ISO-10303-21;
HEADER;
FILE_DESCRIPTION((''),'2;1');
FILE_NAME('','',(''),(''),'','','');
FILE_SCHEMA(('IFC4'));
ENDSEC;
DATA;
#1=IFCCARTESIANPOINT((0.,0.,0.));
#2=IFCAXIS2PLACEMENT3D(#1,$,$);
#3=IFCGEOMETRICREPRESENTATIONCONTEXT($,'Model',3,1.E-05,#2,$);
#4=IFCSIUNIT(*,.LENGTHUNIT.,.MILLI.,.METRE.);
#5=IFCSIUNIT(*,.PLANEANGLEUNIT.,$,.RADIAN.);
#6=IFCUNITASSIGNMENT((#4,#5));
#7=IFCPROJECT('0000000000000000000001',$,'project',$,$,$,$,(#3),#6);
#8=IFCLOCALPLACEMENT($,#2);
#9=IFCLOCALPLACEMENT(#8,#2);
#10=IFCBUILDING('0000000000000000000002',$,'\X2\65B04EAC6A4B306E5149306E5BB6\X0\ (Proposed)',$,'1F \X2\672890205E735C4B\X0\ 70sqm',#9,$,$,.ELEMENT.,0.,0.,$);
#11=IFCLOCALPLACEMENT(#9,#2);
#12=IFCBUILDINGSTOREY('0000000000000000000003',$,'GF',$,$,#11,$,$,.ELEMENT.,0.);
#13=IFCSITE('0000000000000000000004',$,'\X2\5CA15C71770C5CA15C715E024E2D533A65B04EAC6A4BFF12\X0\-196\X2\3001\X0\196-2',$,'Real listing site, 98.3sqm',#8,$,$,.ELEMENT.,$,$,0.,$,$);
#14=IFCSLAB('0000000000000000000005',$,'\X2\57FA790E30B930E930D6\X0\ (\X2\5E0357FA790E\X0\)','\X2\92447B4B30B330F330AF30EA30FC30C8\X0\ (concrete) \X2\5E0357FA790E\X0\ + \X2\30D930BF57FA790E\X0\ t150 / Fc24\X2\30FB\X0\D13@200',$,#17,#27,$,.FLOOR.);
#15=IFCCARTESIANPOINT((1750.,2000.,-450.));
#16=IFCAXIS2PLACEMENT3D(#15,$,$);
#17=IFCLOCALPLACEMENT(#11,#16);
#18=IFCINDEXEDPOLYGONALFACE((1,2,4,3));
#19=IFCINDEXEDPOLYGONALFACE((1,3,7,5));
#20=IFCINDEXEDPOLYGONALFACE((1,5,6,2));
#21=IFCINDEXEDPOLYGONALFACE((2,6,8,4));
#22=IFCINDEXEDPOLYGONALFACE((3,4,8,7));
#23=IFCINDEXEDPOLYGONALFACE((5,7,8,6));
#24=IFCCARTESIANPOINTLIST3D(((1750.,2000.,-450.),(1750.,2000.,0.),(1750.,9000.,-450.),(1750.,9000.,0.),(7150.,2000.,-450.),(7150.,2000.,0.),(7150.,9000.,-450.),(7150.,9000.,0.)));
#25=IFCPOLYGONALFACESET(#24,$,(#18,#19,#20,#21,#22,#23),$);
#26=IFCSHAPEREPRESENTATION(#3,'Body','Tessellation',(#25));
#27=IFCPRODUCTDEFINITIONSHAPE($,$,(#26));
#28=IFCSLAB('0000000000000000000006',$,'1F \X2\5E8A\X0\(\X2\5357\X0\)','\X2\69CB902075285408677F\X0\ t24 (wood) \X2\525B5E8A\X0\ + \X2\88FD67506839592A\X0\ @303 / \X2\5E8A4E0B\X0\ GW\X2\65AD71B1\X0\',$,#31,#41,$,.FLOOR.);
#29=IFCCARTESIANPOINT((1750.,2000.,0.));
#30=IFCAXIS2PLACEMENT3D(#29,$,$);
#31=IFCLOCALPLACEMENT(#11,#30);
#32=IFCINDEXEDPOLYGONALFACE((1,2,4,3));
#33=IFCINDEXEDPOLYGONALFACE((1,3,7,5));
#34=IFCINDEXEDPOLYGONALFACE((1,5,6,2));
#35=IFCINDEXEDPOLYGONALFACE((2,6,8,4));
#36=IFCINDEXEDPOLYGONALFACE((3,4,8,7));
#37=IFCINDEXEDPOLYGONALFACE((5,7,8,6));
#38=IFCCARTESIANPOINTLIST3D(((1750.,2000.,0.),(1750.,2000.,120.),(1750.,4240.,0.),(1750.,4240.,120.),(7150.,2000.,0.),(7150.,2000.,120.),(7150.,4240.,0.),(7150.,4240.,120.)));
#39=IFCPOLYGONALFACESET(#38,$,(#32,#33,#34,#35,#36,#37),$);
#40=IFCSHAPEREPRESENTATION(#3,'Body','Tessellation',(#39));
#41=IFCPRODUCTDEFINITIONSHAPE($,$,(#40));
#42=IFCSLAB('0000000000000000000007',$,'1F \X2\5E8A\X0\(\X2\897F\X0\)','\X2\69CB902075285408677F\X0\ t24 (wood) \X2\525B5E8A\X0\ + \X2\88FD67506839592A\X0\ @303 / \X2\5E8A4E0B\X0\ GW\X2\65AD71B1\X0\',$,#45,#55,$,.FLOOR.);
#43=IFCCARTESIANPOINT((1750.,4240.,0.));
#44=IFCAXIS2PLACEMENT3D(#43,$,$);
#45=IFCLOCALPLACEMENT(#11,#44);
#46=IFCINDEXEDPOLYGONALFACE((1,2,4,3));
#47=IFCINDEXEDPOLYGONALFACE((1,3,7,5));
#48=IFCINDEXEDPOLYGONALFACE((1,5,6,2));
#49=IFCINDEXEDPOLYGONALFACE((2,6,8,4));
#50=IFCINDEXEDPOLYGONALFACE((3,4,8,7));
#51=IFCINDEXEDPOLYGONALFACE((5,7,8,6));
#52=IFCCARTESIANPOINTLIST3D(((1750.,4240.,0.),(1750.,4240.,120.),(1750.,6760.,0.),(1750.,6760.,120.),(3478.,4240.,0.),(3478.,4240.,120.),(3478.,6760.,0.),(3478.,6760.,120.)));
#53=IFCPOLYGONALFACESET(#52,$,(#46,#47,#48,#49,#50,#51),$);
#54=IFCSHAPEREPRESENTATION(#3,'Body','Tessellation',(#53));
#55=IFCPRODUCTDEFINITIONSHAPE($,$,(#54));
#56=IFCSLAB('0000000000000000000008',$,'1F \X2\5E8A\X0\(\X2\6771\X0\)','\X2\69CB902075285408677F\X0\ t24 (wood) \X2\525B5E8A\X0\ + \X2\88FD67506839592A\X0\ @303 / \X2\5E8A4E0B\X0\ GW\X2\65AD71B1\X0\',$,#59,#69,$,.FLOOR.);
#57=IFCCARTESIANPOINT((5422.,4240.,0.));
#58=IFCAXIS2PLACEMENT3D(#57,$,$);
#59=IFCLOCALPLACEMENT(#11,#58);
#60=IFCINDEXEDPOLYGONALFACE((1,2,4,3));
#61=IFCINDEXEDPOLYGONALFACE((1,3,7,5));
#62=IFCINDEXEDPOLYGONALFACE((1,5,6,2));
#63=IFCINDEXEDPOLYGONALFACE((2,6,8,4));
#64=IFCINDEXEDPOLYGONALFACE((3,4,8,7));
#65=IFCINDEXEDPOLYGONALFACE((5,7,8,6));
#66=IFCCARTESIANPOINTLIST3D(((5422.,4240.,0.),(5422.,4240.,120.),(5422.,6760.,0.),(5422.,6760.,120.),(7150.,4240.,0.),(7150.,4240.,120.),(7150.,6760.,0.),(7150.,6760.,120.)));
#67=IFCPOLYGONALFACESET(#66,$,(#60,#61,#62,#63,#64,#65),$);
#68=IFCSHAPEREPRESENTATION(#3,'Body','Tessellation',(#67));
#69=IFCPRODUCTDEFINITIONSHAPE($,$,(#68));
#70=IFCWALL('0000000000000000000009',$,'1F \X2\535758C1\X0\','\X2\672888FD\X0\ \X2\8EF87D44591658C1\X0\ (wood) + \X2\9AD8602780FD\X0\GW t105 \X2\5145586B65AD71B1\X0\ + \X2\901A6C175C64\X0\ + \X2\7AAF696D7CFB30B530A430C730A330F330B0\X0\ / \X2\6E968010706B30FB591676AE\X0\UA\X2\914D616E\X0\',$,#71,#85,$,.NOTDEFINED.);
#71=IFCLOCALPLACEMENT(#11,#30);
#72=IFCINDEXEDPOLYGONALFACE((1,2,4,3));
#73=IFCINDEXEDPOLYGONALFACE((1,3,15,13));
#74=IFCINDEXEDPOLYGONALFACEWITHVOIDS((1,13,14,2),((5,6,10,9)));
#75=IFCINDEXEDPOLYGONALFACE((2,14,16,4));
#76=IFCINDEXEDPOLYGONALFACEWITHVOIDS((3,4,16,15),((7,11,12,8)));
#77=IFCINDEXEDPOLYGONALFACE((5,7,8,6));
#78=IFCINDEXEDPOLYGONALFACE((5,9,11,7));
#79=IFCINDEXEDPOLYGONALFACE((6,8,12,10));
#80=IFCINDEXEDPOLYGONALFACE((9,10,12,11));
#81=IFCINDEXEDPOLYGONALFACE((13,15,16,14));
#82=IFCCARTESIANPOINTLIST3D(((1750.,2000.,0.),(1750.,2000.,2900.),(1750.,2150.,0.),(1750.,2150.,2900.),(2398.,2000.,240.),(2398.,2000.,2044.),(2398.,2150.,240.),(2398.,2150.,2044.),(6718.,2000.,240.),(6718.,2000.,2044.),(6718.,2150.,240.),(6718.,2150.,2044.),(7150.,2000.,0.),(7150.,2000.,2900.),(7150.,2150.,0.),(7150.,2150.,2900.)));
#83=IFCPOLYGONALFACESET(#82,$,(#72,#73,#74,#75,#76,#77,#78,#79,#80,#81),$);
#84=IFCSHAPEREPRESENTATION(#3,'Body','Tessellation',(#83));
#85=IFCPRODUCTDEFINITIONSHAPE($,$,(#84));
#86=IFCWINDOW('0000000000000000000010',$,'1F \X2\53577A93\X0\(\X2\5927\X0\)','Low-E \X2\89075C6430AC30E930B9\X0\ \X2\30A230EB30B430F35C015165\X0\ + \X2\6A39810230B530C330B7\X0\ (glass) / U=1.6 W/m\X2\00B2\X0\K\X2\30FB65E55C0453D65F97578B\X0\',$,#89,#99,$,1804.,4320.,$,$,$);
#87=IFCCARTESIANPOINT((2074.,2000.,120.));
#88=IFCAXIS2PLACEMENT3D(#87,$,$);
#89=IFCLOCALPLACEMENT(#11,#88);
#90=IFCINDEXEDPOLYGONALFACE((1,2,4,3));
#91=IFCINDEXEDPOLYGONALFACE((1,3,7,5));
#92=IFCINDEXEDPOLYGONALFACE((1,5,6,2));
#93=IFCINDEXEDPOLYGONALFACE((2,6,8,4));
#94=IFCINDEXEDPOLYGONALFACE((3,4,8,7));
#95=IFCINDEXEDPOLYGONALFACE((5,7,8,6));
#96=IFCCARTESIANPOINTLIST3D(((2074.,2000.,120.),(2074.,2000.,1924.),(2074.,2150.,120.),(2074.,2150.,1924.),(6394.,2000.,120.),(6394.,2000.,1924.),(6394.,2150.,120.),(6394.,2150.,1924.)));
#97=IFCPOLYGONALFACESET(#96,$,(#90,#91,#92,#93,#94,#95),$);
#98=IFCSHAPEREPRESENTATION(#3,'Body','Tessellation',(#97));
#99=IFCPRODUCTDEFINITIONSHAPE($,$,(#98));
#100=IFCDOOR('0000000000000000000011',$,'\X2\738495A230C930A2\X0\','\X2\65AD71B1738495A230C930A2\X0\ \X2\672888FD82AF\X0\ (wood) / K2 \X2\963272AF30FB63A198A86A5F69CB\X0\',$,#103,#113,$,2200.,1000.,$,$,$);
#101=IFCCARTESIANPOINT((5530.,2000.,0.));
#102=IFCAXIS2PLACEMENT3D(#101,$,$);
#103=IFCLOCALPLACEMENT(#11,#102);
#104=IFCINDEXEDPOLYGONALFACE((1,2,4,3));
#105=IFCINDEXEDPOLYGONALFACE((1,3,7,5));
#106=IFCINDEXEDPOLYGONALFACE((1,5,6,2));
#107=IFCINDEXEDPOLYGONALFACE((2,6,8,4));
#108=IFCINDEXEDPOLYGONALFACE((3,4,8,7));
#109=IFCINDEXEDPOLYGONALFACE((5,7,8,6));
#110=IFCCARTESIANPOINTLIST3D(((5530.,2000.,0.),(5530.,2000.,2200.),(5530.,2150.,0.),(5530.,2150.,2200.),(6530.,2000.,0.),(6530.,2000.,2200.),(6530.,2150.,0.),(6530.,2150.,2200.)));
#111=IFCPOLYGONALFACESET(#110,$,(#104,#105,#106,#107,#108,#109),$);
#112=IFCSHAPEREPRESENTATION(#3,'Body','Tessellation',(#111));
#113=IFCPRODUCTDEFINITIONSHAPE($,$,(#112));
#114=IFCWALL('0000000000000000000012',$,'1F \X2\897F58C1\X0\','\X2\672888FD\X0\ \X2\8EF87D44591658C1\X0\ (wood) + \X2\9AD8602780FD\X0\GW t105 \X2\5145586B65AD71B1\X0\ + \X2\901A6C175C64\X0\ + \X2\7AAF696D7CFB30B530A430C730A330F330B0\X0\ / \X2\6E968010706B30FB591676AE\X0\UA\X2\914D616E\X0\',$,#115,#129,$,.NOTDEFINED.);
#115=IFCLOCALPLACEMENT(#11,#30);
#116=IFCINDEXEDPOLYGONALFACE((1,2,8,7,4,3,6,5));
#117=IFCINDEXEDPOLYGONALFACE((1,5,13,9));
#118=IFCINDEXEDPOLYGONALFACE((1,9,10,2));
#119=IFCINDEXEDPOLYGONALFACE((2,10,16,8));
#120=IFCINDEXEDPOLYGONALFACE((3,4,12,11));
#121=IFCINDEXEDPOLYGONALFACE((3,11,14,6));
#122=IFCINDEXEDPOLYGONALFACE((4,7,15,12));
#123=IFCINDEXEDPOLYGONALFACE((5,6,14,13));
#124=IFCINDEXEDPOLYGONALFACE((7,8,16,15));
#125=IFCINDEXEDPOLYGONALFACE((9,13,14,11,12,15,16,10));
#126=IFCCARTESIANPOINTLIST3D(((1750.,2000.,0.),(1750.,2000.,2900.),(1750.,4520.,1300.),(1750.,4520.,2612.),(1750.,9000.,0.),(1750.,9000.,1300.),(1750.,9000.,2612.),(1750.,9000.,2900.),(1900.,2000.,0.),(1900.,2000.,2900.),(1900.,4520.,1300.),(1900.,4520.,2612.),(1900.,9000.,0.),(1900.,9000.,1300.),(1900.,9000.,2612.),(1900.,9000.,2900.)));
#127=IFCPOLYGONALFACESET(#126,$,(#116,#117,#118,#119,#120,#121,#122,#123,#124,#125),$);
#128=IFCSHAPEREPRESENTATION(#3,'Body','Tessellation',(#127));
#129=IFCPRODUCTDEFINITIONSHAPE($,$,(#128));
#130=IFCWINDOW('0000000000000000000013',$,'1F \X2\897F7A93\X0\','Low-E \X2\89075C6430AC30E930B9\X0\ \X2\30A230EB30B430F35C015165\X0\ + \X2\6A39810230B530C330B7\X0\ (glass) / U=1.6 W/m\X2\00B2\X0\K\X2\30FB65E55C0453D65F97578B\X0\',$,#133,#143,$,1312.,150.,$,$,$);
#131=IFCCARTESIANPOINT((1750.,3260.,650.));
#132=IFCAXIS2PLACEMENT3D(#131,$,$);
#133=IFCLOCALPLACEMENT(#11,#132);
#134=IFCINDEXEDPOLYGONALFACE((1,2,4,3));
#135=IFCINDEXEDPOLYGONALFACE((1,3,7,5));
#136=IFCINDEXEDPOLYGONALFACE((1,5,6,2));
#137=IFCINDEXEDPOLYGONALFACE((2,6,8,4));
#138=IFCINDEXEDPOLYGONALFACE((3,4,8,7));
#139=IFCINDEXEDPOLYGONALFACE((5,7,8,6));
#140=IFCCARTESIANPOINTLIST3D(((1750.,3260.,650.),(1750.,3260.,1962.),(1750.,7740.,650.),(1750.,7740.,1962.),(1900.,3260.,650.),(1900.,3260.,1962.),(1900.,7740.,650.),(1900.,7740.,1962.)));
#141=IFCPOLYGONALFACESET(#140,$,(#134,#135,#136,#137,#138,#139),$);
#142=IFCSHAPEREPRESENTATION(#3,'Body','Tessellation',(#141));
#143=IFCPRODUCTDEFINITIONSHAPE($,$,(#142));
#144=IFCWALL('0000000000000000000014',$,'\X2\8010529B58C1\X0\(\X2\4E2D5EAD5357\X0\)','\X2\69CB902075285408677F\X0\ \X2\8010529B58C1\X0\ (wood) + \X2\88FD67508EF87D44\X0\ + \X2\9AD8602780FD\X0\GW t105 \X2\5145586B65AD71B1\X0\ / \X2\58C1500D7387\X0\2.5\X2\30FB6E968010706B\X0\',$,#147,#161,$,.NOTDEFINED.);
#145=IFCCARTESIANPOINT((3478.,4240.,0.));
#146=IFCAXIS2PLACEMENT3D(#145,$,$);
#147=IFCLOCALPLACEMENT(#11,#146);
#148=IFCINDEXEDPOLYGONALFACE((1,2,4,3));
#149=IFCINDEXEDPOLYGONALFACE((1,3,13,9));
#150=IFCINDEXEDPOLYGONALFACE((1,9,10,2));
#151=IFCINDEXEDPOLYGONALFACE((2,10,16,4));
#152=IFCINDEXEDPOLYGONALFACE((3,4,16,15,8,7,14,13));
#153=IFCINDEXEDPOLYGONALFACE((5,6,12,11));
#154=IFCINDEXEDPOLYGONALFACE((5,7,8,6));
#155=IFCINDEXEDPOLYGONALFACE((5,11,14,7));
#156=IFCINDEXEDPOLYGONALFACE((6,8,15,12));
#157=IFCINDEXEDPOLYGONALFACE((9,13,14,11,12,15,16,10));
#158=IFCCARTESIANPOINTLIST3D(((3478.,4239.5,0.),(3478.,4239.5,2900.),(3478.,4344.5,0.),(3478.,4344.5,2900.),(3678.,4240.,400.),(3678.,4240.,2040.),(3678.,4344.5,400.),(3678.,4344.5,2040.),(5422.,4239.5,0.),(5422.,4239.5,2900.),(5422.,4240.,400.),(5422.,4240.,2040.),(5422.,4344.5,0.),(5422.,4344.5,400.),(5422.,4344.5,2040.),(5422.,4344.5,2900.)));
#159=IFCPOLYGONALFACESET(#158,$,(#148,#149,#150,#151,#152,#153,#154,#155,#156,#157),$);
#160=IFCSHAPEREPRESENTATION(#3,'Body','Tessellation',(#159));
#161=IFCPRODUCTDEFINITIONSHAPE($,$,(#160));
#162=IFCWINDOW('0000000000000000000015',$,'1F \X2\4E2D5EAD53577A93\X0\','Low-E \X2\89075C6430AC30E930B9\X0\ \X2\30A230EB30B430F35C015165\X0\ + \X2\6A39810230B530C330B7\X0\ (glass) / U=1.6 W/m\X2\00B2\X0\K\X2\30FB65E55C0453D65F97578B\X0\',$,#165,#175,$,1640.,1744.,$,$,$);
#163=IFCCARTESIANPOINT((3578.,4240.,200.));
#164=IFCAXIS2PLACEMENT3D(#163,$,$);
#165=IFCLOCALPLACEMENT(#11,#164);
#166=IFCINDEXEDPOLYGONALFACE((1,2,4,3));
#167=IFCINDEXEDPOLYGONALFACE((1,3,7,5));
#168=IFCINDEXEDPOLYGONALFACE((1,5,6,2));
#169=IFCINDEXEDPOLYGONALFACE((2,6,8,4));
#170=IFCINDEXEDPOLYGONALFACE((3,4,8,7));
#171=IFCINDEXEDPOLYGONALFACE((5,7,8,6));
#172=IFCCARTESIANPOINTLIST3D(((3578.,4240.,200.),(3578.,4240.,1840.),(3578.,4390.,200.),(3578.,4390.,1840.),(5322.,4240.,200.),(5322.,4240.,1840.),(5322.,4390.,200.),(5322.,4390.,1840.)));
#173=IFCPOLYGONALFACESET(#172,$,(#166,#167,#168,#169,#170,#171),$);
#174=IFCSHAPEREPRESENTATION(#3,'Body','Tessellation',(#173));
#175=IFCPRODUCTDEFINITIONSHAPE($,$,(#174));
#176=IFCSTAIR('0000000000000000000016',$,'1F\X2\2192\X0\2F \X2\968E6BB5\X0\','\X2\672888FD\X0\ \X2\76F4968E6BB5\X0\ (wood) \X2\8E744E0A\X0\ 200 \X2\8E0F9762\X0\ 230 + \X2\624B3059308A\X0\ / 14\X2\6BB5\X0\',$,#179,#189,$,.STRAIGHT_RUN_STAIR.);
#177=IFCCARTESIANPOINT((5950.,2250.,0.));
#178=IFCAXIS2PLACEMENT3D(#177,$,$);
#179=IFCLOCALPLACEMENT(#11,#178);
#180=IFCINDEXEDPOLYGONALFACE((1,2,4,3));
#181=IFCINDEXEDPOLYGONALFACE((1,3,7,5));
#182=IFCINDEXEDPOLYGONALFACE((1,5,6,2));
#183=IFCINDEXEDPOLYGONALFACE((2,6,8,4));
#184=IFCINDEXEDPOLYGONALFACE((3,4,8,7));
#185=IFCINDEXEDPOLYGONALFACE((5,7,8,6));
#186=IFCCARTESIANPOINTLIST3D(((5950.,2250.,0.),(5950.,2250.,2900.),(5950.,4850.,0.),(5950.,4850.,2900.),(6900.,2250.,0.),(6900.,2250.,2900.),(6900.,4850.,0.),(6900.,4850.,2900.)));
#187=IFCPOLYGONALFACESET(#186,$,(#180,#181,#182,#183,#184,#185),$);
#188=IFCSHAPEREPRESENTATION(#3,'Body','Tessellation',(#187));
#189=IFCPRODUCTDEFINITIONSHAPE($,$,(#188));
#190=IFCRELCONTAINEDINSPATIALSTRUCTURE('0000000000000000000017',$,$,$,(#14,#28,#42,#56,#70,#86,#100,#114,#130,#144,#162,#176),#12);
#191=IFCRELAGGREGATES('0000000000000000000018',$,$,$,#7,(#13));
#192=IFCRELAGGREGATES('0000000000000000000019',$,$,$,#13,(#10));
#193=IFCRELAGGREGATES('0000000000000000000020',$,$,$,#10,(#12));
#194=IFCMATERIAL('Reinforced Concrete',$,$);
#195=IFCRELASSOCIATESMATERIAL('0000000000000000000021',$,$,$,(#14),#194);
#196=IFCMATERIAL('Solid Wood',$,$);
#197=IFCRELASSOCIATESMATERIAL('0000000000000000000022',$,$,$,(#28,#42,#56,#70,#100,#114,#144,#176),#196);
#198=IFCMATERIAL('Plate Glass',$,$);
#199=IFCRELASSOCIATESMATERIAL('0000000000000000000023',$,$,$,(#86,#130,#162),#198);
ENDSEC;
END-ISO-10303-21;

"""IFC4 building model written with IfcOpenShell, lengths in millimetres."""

from ifc_helpers import new_model, si_unit, frame, frame_2d, origin, place, context, project, spatial, rectangle, extrude, material, element, fill, save


model = new_model("IFC4")

# Units and contexts
model_context = context("Model", 3, precision=1e-05, world=origin())
ifc_project = project(units=[si_unit("LENGTHUNIT", "METRE", prefix="MILLI"), si_unit("PLANEANGLEUNIT", "RADIAN")], contexts=[model_context])

# Site, building, storey
site_placement = place(None, origin())
site = spatial("IfcSite", under=ifc_project, at=site_placement, Name="岡山県岡山市中区新京橋２-196、196-2", ObjectType="Real listing site, 98.3sqm", CompositionType="ELEMENT", RefElevation=0.0)
building_placement = place(site_placement, origin())
building = spatial("IfcBuilding", under=site, at=building_placement, Name="新京橋の光の家 (Proposed)", ObjectType="1F 木造平屋 70sqm", CompositionType="ELEMENT", ElevationOfRefHeight=0.0, ElevationOfTerrain=0.0)
storey_placement = place(building_placement, origin())
storey = spatial("IfcBuildingStorey", under=building, at=storey_placement, Name="GF", CompositionType="ELEMENT", Elevation=0.0)

# Slabs
ifc_material_1 = material(Name="Reinforced Concrete")
slab_1_placement = place(storey_placement, frame((1750.0, 2000.0, -450.0)))
element("IfcSlab", 1, at=slab_1_placement, inside=storey, material=ifc_material_1, Name="基礎スラブ (布基礎)", Description="鉄筋コンクリート (concrete) 布基礎 + ベタ基礎 t150 / Fc24・D13@200", PredefinedType="FLOOR", context=model_context, shape_type="SweptSolid", body=[
    extrude(rectangle(XDim=5400.0, YDim=7000.0, at=frame_2d((2700.0, 3500.0))), frame((1750.0, 2000.0, -450.0)), (0.0, 0.0, 1.0), 450.0),
])
ifc_material_2 = material(Name="Solid Wood")
slab_2_placement = place(storey_placement, frame((1750.0, 2000.0, 0.0)))
element("IfcSlab", 2, at=slab_2_placement, inside=storey, material=ifc_material_2, Name="1F 床(南)", Description="構造用合板 t24 (wood) 剛床 + 製材根太 @303 / 床下 GW断熱", PredefinedType="FLOOR", context=model_context, shape_type="SweptSolid", body=[
    extrude(rectangle(XDim=5400.0, YDim=2240.0, at=frame_2d((2700.0, 1120.0))), frame((1750.0, 2000.0, 0.0)), (0.0, 0.0, 1.0), 120.0),
])
slab_3_placement = place(storey_placement, frame((1750.0, 4240.0, 0.0)))
element("IfcSlab", 3, at=slab_3_placement, inside=storey, material=ifc_material_2, Name="1F 床(西)", Description="構造用合板 t24 (wood) 剛床 + 製材根太 @303 / 床下 GW断熱", PredefinedType="FLOOR", context=model_context, shape_type="SweptSolid", body=[
    extrude(rectangle(XDim=1728.0, YDim=2520.0, at=frame_2d((864.0, 1260.0))), frame((1750.0, 4240.0, 0.0)), (0.0, 0.0, 1.0), 120.0),
])
slab_4_placement = place(storey_placement, frame((5422.0, 4240.0, 0.0)))
element("IfcSlab", 4, at=slab_4_placement, inside=storey, material=ifc_material_2, Name="1F 床(東)", Description="構造用合板 t24 (wood) 剛床 + 製材根太 @303 / 床下 GW断熱", PredefinedType="FLOOR", context=model_context, shape_type="SweptSolid", body=[
    extrude(rectangle(XDim=1728.0, YDim=2520.0, at=frame_2d((864.0, 1260.0))), frame((5422.0, 4240.0, 0.0)), (0.0, 0.0, 1.0), 120.0),
])

# Wall, openings, window, door
wall_1_placement = place(storey_placement, frame((1750.0, 2000.0, 0.0)))
wall_1 = element("IfcWall", 5, at=wall_1_placement, inside=storey, material=ifc_material_2, Name="1F 南壁", Description="木製 軸組外壁 (wood) + 高性能GW t105 充填断熱 + 通気層 + 窯業系サイディング / 準耐火・外皮UA配慮", PredefinedType="NOTDEFINED", context=model_context, shape_type="SweptSolid", body=[
    extrude(rectangle(XDim=5400.0, YDim=150.0, at=frame_2d((2700.0, 75.0))), frame((1750.0, 2000.0, 0.0)), (0.0, 0.0, 1.0), 2900.0),
])
opening_1_placement = place(storey_placement, frame((2074.0, 2000.0, 120.0)))
opening_1 = element("IfcOpeningElement", 6, at=opening_1_placement, cuts=wall_1, PredefinedType="NOTDEFINED", context=model_context, shape_type="SweptSolid", body=[
    extrude(rectangle(XDim=4320.0, YDim=150.0, at=frame_2d((2160.0, 75.0))), frame((2074.0, 2000.0, 120.0)), (0.0, 0.0, 1.0), 1804.0),
])
opening_2_placement = place(storey_placement, frame((5530.0, 2000.0, 0.0)))
opening_2 = element("IfcOpeningElement", 7, at=opening_2_placement, cuts=wall_1, PredefinedType="NOTDEFINED", context=model_context, shape_type="SweptSolid", body=[
    extrude(rectangle(XDim=1000.0, YDim=150.0, at=frame_2d((500.0, 75.0))), frame((5530.0, 2000.0, 0.0)), (0.0, 0.0, 1.0), 2200.0),
])
ifc_material_3 = material(Name="Plate Glass")
window_1_placement = place(storey_placement, frame((2074.0, 2000.0, 120.0)))
window_1 = element("IfcWindow", 8, at=window_1_placement, inside=storey, material=ifc_material_3, Name="1F 南窓(大)", Description="Low-E 複層ガラス アルゴン封入 + 樹脂サッシ (glass) / U=1.6 W/m²K・日射取得型", OverallHeight=1804.0, OverallWidth=4320.0, context=model_context, shape_type="SweptSolid", body=[
    extrude(rectangle(XDim=4320.0, YDim=150.0, at=frame_2d((2160.0, 75.0))), frame((2074.0, 2000.0, 120.0)), (0.0, 0.0, 1.0), 1804.0),
])
fill(opening_1, window_1)
door_placement = place(storey_placement, frame((5530.0, 2000.0, 0.0)))
door = element("IfcDoor", 9, at=door_placement, inside=storey, material=ifc_material_2, Name="玄関ドア", Description="断熱玄関ドア 木製芯 (wood) / K2 防犯・採風機構", OverallHeight=2200.0, OverallWidth=1000.0, context=model_context, shape_type="SweptSolid", body=[
    extrude(rectangle(XDim=1000.0, YDim=150.0, at=frame_2d((500.0, 75.0))), frame((5530.0, 2000.0, 0.0)), (0.0, 0.0, 1.0), 2200.0),
])
fill(opening_2, door)

# Walls, openings, windows
wall_2_placement = place(storey_placement, frame((1750.0, 2000.0, 0.0)))
wall_2 = element("IfcWall", 10, at=wall_2_placement, inside=storey, material=ifc_material_2, Name="1F 西壁", Description="木製 軸組外壁 (wood) + 高性能GW t105 充填断熱 + 通気層 + 窯業系サイディング / 準耐火・外皮UA配慮", PredefinedType="NOTDEFINED", context=model_context, shape_type="SweptSolid", body=[
    extrude(rectangle(XDim=150.0, YDim=7000.0, at=frame_2d((75.0, 3500.0))), frame((1750.0, 2000.0, 0.0)), (0.0, 0.0, 1.0), 2900.0),
])
opening_3_placement = place(storey_placement, frame((1750.0, 3260.0, 650.0)))
opening_3 = element("IfcOpeningElement", 11, at=opening_3_placement, cuts=wall_2, PredefinedType="NOTDEFINED", context=model_context, shape_type="SweptSolid", body=[
    extrude(rectangle(XDim=150.0, YDim=4480.0, at=frame_2d((75.0, 2240.0))), frame((1750.0, 3260.0, 650.0)), (0.0, 0.0, 1.0), 1312.0),
])
window_2_placement = place(storey_placement, frame((1750.0, 3260.0, 650.0)))
window_2 = element("IfcWindow", 12, at=window_2_placement, inside=storey, material=ifc_material_3, Name="1F 西窓", Description="Low-E 複層ガラス アルゴン封入 + 樹脂サッシ (glass) / U=1.6 W/m²K・日射取得型", OverallHeight=1312.0, OverallWidth=150.0, context=model_context, shape_type="SweptSolid", body=[
    extrude(rectangle(XDim=150.0, YDim=4480.0, at=frame_2d((75.0, 2240.0))), frame((1750.0, 3260.0, 650.0)), (0.0, 0.0, 1.0), 1312.0),
])
fill(opening_3, window_2)
wall_3_placement = place(storey_placement, frame((3478.0, 4240.0, 0.0)))
wall_3 = element("IfcWall", 13, at=wall_3_placement, inside=storey, material=ifc_material_2, Name="耐力壁(中庭南)", Description="構造用合板 耐力壁 (wood) + 製材軸組 + 高性能GW t105 充填断熱 / 壁倍率2.5・準耐火", PredefinedType="NOTDEFINED", context=model_context, shape_type="SweptSolid", body=[
    extrude(rectangle(XDim=1944.0, YDim=105.0, at=frame_2d((972.0, 52.0))), frame((3478.0, 4240.0, 0.0)), (0.0, 0.0, 1.0), 2900.0),
])
opening_4_placement = place(storey_placement, frame((3578.0, 4240.0, 200.0)))
opening_4 = element("IfcOpeningElement", 14, at=opening_4_placement, cuts=wall_3, PredefinedType="NOTDEFINED", context=model_context, shape_type="SweptSolid", body=[
    extrude(rectangle(XDim=1744.0, YDim=150.0, at=frame_2d((872.0, 75.0))), frame((3578.0, 4240.0, 200.0)), (0.0, 0.0, 1.0), 1640.0),
])
window_3_placement = place(storey_placement, frame((3578.0, 4240.0, 200.0)))
window_3 = element("IfcWindow", 15, at=window_3_placement, inside=storey, material=ifc_material_3, Name="1F 中庭南窓", Description="Low-E 複層ガラス アルゴン封入 + 樹脂サッシ (glass) / U=1.6 W/m²K・日射取得型", OverallHeight=1640.0, OverallWidth=1744.0, context=model_context, shape_type="SweptSolid", body=[
    extrude(rectangle(XDim=1744.0, YDim=150.0, at=frame_2d((872.0, 75.0))), frame((3578.0, 4240.0, 200.0)), (0.0, 0.0, 1.0), 1640.0),
])
fill(opening_4, window_3)

# Stair
stair_placement = place(storey_placement, frame((5950.0, 2250.0, 0.0)))
element("IfcStair", 16, at=stair_placement, inside=storey, material=ifc_material_2, Name="1F→2F 階段", Description="木製 直階段 (wood) 蹴上 200 踏面 230 + 手すり / 14段", PredefinedType="STRAIGHT_RUN_STAIR", context=model_context, shape_type="SweptSolid", body=[
    extrude(rectangle(XDim=950.0, YDim=2600.0, at=frame_2d((475.0, 1300.0))), frame((5950.0, 2250.0, 0.0)), (0.0, 0.0, 1.0), 2900.0),
])

save(model, "model.ifc")
